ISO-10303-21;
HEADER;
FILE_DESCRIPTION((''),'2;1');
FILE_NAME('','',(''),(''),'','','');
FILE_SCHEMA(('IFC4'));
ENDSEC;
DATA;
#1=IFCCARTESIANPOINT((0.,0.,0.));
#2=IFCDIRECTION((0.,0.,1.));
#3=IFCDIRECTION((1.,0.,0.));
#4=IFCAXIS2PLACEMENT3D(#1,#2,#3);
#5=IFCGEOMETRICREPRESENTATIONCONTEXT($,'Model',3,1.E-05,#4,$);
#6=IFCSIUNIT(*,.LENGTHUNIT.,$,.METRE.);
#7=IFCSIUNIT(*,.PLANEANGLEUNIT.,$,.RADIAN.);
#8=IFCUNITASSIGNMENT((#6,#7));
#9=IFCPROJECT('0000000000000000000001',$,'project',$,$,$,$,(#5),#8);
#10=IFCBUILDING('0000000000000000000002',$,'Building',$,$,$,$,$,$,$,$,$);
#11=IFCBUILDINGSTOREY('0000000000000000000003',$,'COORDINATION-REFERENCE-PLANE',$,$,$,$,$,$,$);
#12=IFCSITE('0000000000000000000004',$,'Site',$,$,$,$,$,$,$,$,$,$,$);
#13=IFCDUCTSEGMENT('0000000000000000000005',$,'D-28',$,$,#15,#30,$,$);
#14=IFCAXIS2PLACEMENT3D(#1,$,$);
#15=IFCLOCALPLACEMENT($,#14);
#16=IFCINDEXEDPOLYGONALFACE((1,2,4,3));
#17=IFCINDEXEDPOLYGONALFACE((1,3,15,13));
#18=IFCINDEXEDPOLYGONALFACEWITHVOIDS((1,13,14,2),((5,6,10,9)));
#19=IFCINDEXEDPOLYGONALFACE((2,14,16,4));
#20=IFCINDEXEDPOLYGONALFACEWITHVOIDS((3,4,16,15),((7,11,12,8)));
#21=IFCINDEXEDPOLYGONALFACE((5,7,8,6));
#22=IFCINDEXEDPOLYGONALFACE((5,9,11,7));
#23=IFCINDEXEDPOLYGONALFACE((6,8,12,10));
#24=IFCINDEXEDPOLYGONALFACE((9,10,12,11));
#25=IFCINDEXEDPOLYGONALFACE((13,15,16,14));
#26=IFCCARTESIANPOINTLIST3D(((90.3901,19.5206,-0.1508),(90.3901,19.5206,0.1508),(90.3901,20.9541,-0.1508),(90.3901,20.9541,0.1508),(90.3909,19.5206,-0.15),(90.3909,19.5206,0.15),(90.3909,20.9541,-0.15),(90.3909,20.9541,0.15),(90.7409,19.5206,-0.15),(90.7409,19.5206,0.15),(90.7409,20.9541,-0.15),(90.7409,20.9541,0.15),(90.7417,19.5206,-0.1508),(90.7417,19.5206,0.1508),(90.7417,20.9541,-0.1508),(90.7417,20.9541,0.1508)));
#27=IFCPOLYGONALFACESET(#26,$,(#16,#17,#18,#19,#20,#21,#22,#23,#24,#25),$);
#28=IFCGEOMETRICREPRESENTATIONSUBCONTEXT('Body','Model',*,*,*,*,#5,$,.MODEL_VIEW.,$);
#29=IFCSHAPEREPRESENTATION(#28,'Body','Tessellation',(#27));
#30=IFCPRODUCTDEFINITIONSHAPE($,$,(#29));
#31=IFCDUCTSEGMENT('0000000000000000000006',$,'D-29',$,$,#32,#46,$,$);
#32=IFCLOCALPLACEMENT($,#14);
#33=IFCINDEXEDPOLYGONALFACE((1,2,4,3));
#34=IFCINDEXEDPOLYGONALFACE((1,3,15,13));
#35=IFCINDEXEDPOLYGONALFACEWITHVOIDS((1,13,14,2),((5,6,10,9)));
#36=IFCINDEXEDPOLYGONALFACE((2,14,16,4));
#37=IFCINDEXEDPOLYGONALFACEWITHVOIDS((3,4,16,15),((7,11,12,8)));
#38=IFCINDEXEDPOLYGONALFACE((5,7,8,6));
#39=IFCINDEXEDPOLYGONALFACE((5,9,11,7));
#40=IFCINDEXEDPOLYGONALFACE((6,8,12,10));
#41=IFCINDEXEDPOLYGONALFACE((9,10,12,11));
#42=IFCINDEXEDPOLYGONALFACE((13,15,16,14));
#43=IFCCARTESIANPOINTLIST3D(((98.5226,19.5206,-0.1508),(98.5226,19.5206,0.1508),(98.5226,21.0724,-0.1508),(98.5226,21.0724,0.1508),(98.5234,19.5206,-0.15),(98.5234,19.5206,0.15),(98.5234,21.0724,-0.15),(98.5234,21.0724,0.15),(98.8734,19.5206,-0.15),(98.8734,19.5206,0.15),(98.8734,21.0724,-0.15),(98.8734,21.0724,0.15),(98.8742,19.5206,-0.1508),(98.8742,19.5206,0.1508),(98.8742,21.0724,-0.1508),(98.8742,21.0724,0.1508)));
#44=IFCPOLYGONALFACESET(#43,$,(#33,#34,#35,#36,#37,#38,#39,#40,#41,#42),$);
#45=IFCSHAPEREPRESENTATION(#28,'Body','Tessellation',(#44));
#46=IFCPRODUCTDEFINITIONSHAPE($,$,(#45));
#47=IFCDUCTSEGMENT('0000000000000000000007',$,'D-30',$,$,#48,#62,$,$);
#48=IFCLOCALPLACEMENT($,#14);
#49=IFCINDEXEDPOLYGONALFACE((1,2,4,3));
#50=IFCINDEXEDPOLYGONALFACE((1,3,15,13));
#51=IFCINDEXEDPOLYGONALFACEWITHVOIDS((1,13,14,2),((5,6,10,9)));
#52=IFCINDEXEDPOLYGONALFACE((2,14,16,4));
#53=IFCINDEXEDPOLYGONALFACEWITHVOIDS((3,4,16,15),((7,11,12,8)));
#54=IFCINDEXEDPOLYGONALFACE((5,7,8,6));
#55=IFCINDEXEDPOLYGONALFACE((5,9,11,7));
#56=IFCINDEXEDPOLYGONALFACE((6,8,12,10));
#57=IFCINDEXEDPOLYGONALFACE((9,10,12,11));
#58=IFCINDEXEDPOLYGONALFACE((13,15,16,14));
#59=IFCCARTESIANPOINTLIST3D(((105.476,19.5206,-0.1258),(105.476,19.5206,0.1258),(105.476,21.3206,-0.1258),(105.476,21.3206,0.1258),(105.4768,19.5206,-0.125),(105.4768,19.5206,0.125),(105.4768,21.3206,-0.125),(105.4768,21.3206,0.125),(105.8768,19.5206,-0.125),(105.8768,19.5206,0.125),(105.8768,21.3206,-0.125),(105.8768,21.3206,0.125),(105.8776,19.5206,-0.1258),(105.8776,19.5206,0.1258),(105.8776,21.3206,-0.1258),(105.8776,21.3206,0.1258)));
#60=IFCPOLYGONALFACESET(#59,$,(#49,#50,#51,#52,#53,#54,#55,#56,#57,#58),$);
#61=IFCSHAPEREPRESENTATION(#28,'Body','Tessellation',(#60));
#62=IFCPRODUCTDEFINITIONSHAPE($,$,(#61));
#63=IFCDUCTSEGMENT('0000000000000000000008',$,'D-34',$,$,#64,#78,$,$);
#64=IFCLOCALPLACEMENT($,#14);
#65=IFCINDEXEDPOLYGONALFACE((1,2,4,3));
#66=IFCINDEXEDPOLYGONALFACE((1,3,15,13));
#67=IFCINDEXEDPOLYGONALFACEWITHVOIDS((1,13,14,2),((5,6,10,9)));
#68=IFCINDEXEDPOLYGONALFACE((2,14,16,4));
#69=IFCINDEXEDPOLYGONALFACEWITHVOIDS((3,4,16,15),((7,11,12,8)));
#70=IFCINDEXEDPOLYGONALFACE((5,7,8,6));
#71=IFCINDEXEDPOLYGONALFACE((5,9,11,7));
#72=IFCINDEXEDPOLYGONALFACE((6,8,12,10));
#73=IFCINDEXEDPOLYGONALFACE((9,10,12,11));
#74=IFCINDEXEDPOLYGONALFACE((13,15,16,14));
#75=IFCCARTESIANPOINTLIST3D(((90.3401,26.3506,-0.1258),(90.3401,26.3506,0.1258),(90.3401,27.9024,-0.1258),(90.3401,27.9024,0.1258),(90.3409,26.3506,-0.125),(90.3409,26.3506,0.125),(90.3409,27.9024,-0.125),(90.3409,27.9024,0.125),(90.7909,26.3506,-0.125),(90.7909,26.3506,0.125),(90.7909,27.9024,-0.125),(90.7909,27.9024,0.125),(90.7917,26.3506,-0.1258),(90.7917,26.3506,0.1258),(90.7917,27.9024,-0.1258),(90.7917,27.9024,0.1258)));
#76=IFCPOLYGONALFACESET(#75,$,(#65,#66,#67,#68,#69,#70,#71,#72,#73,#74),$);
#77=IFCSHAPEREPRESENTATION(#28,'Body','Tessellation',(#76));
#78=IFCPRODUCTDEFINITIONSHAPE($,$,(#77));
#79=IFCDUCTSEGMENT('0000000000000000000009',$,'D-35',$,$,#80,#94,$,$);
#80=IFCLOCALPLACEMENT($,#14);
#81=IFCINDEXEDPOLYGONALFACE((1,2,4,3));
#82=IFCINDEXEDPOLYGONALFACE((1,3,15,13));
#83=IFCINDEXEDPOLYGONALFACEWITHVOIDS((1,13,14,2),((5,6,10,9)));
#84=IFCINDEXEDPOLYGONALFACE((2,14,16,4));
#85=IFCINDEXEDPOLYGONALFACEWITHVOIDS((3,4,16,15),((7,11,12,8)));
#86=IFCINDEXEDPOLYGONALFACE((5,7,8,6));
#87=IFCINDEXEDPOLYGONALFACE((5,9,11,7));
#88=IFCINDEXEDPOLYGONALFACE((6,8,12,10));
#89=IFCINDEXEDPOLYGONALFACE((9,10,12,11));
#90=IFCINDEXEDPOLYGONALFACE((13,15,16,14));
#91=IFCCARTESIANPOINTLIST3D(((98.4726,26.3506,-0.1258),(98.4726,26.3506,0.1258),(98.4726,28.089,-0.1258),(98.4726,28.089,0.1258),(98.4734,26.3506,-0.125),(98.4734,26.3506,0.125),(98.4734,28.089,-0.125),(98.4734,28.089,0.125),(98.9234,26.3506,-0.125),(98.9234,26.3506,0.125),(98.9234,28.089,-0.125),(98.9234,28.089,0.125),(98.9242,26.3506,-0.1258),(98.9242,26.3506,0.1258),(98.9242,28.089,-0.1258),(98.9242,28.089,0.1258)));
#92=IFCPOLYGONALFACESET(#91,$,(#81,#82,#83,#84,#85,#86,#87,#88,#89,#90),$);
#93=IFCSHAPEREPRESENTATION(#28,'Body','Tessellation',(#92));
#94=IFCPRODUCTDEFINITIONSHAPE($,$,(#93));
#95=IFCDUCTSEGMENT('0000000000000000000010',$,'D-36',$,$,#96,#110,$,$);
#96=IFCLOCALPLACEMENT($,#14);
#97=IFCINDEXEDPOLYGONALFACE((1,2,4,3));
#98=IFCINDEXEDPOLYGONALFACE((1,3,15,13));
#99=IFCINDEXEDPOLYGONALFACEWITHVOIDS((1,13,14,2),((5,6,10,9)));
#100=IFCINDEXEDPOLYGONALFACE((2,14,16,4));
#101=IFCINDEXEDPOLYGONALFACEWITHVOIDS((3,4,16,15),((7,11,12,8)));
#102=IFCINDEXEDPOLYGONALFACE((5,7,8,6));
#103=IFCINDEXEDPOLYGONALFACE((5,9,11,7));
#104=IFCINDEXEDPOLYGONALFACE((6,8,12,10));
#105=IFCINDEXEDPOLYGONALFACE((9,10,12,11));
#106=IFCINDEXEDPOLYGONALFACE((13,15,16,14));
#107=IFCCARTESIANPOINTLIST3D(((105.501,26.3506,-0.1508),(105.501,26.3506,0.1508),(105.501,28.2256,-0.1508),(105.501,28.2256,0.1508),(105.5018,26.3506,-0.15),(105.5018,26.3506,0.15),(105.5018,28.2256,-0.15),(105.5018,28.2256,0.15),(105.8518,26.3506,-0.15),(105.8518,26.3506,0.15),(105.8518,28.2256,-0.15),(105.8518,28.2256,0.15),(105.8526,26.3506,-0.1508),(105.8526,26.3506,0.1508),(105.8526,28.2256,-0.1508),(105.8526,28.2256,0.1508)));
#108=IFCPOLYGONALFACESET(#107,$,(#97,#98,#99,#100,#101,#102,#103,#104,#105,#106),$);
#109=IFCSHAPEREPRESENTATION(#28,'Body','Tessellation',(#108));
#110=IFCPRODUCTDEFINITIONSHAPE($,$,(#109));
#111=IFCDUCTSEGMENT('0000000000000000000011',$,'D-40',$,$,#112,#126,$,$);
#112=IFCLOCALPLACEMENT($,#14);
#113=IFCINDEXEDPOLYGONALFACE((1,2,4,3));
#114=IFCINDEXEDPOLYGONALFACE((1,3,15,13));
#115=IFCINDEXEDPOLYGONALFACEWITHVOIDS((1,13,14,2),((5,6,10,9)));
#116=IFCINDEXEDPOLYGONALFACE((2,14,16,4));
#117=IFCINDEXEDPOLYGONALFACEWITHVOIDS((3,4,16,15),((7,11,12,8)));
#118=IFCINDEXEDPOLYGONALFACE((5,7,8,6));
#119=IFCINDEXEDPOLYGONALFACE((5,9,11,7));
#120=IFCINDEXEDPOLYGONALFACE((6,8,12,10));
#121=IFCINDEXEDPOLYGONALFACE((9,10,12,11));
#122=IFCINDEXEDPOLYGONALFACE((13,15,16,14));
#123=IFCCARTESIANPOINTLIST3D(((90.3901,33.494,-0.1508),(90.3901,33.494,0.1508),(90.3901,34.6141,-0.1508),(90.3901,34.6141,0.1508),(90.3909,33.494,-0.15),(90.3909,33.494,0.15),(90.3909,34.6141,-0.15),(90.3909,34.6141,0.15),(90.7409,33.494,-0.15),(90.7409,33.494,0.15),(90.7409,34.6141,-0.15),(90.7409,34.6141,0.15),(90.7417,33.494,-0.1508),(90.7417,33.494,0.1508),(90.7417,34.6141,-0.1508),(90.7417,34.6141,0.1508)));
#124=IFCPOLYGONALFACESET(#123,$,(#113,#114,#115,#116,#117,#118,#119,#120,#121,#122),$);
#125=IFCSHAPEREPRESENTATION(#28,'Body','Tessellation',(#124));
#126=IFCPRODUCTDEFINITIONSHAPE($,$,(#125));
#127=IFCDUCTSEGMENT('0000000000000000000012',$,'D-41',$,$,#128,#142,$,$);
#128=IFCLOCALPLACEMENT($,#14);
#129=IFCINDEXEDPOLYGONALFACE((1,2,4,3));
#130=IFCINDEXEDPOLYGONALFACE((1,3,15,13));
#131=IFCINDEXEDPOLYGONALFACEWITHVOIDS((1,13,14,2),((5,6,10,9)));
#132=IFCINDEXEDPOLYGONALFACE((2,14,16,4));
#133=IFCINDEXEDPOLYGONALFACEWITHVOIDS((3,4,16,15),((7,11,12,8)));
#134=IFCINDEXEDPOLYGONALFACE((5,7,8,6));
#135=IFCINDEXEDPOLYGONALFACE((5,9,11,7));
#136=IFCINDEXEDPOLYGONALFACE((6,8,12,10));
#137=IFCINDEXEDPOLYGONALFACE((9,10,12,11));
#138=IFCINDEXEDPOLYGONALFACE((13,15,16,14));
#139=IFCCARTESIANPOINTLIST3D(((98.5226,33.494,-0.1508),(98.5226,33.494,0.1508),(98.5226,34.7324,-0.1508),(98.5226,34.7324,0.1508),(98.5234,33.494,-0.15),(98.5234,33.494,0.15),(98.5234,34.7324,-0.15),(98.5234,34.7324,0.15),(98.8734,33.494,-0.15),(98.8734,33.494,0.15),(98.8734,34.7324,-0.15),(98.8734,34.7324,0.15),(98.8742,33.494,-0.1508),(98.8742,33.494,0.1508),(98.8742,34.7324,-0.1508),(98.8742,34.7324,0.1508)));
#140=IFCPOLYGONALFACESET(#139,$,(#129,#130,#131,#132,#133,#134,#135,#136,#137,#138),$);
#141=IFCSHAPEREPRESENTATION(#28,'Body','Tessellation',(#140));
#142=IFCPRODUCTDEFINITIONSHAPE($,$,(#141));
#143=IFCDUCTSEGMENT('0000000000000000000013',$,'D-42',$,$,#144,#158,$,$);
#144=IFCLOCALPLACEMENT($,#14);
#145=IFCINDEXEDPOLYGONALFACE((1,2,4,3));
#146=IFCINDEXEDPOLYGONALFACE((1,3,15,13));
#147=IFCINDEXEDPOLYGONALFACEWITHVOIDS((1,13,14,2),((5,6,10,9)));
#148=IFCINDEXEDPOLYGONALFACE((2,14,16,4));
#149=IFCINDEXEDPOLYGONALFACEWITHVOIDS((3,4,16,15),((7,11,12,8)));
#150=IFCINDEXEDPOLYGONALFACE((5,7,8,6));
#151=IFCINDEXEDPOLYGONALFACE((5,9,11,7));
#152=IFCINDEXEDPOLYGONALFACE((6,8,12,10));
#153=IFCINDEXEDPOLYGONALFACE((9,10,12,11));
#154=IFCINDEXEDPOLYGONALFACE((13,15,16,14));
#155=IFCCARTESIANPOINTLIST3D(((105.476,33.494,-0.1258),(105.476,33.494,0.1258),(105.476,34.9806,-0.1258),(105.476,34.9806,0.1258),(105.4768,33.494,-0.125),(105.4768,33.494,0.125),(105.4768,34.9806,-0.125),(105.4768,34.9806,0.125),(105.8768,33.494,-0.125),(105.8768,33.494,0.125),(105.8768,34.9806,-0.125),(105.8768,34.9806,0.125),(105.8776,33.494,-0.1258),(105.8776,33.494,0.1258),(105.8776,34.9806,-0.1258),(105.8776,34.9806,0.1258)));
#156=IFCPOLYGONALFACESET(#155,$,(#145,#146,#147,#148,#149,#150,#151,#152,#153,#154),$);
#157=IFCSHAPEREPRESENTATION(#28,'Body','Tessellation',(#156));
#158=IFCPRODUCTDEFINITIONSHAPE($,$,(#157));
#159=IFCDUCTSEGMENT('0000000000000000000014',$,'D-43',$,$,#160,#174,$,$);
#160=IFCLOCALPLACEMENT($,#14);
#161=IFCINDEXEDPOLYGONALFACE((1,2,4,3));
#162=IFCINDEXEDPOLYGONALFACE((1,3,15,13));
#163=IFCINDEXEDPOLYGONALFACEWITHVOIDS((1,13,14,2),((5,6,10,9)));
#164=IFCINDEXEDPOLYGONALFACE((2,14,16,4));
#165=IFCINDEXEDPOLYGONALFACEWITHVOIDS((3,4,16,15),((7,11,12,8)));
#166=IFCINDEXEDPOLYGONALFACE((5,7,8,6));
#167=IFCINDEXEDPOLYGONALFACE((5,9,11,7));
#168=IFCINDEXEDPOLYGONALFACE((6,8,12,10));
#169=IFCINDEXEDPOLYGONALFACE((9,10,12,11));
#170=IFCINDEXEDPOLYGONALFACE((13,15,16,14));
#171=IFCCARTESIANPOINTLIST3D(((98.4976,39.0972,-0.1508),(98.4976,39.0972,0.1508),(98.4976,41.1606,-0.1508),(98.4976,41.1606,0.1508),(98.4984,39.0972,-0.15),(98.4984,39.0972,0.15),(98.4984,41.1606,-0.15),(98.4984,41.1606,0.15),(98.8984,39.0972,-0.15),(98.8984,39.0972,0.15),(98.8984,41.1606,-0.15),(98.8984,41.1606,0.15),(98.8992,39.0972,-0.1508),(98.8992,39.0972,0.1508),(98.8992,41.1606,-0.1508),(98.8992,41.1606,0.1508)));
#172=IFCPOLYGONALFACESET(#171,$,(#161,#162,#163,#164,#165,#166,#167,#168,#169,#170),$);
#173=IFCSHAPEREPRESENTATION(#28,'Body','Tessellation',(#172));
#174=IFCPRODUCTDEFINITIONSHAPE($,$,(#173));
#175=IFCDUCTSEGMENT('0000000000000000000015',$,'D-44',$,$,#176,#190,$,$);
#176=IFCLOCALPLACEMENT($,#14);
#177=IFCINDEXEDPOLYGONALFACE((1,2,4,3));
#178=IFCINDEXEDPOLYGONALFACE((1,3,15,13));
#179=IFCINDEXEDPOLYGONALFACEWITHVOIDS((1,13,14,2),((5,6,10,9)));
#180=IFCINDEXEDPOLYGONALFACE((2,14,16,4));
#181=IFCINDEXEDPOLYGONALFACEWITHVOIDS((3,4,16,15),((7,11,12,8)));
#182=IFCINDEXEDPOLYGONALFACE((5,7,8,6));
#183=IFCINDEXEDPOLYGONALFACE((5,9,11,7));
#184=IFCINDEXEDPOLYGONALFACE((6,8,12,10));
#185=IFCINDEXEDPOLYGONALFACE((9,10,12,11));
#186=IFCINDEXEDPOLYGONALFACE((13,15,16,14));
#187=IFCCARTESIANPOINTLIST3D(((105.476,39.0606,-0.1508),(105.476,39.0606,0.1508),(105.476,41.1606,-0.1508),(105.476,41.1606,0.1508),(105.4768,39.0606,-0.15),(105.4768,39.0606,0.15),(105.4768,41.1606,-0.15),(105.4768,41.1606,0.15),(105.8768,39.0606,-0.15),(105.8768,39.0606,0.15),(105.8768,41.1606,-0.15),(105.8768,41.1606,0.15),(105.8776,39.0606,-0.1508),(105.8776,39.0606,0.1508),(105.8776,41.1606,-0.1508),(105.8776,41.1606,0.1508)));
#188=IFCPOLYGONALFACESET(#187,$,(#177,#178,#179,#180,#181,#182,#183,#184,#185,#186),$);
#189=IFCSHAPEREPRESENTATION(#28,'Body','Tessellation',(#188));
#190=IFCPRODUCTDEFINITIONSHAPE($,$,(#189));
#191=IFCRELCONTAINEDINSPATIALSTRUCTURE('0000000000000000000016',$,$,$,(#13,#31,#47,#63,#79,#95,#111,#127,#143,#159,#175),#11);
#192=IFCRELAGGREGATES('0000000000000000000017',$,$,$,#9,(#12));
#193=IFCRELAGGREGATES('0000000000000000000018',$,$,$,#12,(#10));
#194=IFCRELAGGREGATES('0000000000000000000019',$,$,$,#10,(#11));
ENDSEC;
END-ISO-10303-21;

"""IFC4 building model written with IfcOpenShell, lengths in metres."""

from ifc_helpers import new_model, si_unit, frame, origin, origin_with_axes, place, context, subcontext, project, spatial, hollow_rectangle, extrude, element, save


model = new_model("IFC4")

# Units and contexts
model_context = context("Model", 3, precision=1e-05, world=origin_with_axes())
body_context = subcontext(model_context, "Body", "Model", "MODEL_VIEW")
ifc_project = project(units=[si_unit("LENGTHUNIT", "METRE"), si_unit("PLANEANGLEUNIT", "RADIAN")], contexts=[model_context])

# Site, building, storey
site = spatial("IfcSite", under=ifc_project, Name="Site")
building = spatial("IfcBuilding", under=site, Name="Building")
storey = spatial("IfcBuildingStorey", under=building, Name="COORDINATION-REFERENCE-PLANE")

# Duct segments
duct_segment_1_placement = place(None, frame((90.5659, 19.5206, 0.0), z_axis=(0.0, 1.0, 0.0), x_axis=(1.0, 0.0, 0.0)))
element("IfcDuctSegment", 1, at=duct_segment_1_placement, inside=storey, Name="D-28", context=body_context, shape_type="SweptSolid", body=[
    extrude(hollow_rectangle(XDim=0.3516, YDim=0.3016, WallThickness=0.0008), origin(), (0.0, 0.0, 1.0), 1.4335),
])
duct_segment_2_placement = place(None, frame((98.6984, 19.5206, 0.0), z_axis=(0.0, 1.0, 0.0), x_axis=(1.0, 0.0, 0.0)))
element("IfcDuctSegment", 2, at=duct_segment_2_placement, inside=storey, Name="D-29", context=body_context, shape_type="SweptSolid", body=[
    extrude(hollow_rectangle(XDim=0.3516, YDim=0.3016, WallThickness=0.0008), origin(), (0.0, 0.0, 1.0), 1.5518),
])
duct_segment_3_placement = place(None, frame((105.6768, 19.5206, 0.0), z_axis=(0.0, 1.0, 0.0), x_axis=(1.0, 0.0, 0.0)))
element("IfcDuctSegment", 3, at=duct_segment_3_placement, inside=storey, Name="D-30", context=body_context, shape_type="SweptSolid", body=[
    extrude(hollow_rectangle(XDim=0.4016, YDim=0.2516, WallThickness=0.0008), origin(), (0.0, 0.0, 1.0), 1.8),
])
duct_segment_4_placement = place(None, frame((90.5659, 26.3506, 0.0), z_axis=(0.0, 1.0, 0.0), x_axis=(1.0, 0.0, 0.0)))
element("IfcDuctSegment", 4, at=duct_segment_4_placement, inside=storey, Name="D-34", context=body_context, shape_type="SweptSolid", body=[
    extrude(hollow_rectangle(XDim=0.4516, YDim=0.2516, WallThickness=0.0008), origin(), (0.0, 0.0, 1.0), 1.5518),
])
duct_segment_5_placement = place(None, frame((98.6984, 26.3506, 0.0), z_axis=(0.0, 1.0, 0.0), x_axis=(1.0, 0.0, 0.0)))
element("IfcDuctSegment", 5, at=duct_segment_5_placement, inside=storey, Name="D-35", context=body_context, shape_type="SweptSolid", body=[
    extrude(hollow_rectangle(XDim=0.4516, YDim=0.2516, WallThickness=0.0008), origin(), (0.0, 0.0, 1.0), 1.7384),
])
duct_segment_6_placement = place(None, frame((105.6768, 26.3506, 0.0), z_axis=(0.0, 1.0, 0.0), x_axis=(1.0, 0.0, 0.0)))
element("IfcDuctSegment", 6, at=duct_segment_6_placement, inside=storey, Name="D-36", context=body_context, shape_type="SweptSolid", body=[
    extrude(hollow_rectangle(XDim=0.3516, YDim=0.3016, WallThickness=0.0008), origin(), (0.0, 0.0, 1.0), 1.875),
])
duct_segment_7_placement = place(None, frame((90.5659, 33.494, 0.0), z_axis=(0.0, 1.0, 0.0), x_axis=(1.0, 0.0, 0.0)))
element("IfcDuctSegment", 7, at=duct_segment_7_placement, inside=storey, Name="D-40", context=body_context, shape_type="SweptSolid", body=[
    extrude(hollow_rectangle(XDim=0.3516, YDim=0.3016, WallThickness=0.0008), origin(), (0.0, 0.0, 1.0), 1.12),
])
duct_segment_8_placement = place(None, frame((98.6984, 33.494, 0.0), z_axis=(0.0, 1.0, 0.0), x_axis=(1.0, 0.0, 0.0)))
element("IfcDuctSegment", 8, at=duct_segment_8_placement, inside=storey, Name="D-41", context=body_context, shape_type="SweptSolid", body=[
    extrude(hollow_rectangle(XDim=0.3516, YDim=0.3016, WallThickness=0.0008), origin(), (0.0, 0.0, 1.0), 1.2383),
])
duct_segment_9_placement = place(None, frame((105.6768, 33.494, 0.0), z_axis=(0.0, 1.0, 0.0), x_axis=(1.0, 0.0, 0.0)))
element("IfcDuctSegment", 9, at=duct_segment_9_placement, inside=storey, Name="D-42", context=body_context, shape_type="SweptSolid", body=[
    extrude(hollow_rectangle(XDim=0.4016, YDim=0.2516, WallThickness=0.0008), origin(), (0.0, 0.0, 1.0), 1.4865),
])
duct_segment_10_placement = place(None, frame((98.6984, 39.0972, 0.0), z_axis=(0.0, 1.0, 0.0), x_axis=(1.0, 0.0, 0.0)))
element("IfcDuctSegment", 10, at=duct_segment_10_placement, inside=storey, Name="D-43", context=body_context, shape_type="SweptSolid", body=[
    extrude(hollow_rectangle(XDim=0.4016, YDim=0.3016, WallThickness=0.0008), origin(), (0.0, 0.0, 1.0), 2.0634),
])
duct_segment_11_placement = place(None, frame((105.6768, 39.0606, 0.0), z_axis=(0.0, 1.0, 0.0), x_axis=(1.0, 0.0, 0.0)))
element("IfcDuctSegment", 11, at=duct_segment_11_placement, inside=storey, Name="D-44", context=body_context, shape_type="SweptSolid", body=[
    extrude(hollow_rectangle(XDim=0.4016, YDim=0.3016, WallThickness=0.0008), origin(), (0.0, 0.0, 1.0), 2.1),
])

save(model, "model.ifc")
